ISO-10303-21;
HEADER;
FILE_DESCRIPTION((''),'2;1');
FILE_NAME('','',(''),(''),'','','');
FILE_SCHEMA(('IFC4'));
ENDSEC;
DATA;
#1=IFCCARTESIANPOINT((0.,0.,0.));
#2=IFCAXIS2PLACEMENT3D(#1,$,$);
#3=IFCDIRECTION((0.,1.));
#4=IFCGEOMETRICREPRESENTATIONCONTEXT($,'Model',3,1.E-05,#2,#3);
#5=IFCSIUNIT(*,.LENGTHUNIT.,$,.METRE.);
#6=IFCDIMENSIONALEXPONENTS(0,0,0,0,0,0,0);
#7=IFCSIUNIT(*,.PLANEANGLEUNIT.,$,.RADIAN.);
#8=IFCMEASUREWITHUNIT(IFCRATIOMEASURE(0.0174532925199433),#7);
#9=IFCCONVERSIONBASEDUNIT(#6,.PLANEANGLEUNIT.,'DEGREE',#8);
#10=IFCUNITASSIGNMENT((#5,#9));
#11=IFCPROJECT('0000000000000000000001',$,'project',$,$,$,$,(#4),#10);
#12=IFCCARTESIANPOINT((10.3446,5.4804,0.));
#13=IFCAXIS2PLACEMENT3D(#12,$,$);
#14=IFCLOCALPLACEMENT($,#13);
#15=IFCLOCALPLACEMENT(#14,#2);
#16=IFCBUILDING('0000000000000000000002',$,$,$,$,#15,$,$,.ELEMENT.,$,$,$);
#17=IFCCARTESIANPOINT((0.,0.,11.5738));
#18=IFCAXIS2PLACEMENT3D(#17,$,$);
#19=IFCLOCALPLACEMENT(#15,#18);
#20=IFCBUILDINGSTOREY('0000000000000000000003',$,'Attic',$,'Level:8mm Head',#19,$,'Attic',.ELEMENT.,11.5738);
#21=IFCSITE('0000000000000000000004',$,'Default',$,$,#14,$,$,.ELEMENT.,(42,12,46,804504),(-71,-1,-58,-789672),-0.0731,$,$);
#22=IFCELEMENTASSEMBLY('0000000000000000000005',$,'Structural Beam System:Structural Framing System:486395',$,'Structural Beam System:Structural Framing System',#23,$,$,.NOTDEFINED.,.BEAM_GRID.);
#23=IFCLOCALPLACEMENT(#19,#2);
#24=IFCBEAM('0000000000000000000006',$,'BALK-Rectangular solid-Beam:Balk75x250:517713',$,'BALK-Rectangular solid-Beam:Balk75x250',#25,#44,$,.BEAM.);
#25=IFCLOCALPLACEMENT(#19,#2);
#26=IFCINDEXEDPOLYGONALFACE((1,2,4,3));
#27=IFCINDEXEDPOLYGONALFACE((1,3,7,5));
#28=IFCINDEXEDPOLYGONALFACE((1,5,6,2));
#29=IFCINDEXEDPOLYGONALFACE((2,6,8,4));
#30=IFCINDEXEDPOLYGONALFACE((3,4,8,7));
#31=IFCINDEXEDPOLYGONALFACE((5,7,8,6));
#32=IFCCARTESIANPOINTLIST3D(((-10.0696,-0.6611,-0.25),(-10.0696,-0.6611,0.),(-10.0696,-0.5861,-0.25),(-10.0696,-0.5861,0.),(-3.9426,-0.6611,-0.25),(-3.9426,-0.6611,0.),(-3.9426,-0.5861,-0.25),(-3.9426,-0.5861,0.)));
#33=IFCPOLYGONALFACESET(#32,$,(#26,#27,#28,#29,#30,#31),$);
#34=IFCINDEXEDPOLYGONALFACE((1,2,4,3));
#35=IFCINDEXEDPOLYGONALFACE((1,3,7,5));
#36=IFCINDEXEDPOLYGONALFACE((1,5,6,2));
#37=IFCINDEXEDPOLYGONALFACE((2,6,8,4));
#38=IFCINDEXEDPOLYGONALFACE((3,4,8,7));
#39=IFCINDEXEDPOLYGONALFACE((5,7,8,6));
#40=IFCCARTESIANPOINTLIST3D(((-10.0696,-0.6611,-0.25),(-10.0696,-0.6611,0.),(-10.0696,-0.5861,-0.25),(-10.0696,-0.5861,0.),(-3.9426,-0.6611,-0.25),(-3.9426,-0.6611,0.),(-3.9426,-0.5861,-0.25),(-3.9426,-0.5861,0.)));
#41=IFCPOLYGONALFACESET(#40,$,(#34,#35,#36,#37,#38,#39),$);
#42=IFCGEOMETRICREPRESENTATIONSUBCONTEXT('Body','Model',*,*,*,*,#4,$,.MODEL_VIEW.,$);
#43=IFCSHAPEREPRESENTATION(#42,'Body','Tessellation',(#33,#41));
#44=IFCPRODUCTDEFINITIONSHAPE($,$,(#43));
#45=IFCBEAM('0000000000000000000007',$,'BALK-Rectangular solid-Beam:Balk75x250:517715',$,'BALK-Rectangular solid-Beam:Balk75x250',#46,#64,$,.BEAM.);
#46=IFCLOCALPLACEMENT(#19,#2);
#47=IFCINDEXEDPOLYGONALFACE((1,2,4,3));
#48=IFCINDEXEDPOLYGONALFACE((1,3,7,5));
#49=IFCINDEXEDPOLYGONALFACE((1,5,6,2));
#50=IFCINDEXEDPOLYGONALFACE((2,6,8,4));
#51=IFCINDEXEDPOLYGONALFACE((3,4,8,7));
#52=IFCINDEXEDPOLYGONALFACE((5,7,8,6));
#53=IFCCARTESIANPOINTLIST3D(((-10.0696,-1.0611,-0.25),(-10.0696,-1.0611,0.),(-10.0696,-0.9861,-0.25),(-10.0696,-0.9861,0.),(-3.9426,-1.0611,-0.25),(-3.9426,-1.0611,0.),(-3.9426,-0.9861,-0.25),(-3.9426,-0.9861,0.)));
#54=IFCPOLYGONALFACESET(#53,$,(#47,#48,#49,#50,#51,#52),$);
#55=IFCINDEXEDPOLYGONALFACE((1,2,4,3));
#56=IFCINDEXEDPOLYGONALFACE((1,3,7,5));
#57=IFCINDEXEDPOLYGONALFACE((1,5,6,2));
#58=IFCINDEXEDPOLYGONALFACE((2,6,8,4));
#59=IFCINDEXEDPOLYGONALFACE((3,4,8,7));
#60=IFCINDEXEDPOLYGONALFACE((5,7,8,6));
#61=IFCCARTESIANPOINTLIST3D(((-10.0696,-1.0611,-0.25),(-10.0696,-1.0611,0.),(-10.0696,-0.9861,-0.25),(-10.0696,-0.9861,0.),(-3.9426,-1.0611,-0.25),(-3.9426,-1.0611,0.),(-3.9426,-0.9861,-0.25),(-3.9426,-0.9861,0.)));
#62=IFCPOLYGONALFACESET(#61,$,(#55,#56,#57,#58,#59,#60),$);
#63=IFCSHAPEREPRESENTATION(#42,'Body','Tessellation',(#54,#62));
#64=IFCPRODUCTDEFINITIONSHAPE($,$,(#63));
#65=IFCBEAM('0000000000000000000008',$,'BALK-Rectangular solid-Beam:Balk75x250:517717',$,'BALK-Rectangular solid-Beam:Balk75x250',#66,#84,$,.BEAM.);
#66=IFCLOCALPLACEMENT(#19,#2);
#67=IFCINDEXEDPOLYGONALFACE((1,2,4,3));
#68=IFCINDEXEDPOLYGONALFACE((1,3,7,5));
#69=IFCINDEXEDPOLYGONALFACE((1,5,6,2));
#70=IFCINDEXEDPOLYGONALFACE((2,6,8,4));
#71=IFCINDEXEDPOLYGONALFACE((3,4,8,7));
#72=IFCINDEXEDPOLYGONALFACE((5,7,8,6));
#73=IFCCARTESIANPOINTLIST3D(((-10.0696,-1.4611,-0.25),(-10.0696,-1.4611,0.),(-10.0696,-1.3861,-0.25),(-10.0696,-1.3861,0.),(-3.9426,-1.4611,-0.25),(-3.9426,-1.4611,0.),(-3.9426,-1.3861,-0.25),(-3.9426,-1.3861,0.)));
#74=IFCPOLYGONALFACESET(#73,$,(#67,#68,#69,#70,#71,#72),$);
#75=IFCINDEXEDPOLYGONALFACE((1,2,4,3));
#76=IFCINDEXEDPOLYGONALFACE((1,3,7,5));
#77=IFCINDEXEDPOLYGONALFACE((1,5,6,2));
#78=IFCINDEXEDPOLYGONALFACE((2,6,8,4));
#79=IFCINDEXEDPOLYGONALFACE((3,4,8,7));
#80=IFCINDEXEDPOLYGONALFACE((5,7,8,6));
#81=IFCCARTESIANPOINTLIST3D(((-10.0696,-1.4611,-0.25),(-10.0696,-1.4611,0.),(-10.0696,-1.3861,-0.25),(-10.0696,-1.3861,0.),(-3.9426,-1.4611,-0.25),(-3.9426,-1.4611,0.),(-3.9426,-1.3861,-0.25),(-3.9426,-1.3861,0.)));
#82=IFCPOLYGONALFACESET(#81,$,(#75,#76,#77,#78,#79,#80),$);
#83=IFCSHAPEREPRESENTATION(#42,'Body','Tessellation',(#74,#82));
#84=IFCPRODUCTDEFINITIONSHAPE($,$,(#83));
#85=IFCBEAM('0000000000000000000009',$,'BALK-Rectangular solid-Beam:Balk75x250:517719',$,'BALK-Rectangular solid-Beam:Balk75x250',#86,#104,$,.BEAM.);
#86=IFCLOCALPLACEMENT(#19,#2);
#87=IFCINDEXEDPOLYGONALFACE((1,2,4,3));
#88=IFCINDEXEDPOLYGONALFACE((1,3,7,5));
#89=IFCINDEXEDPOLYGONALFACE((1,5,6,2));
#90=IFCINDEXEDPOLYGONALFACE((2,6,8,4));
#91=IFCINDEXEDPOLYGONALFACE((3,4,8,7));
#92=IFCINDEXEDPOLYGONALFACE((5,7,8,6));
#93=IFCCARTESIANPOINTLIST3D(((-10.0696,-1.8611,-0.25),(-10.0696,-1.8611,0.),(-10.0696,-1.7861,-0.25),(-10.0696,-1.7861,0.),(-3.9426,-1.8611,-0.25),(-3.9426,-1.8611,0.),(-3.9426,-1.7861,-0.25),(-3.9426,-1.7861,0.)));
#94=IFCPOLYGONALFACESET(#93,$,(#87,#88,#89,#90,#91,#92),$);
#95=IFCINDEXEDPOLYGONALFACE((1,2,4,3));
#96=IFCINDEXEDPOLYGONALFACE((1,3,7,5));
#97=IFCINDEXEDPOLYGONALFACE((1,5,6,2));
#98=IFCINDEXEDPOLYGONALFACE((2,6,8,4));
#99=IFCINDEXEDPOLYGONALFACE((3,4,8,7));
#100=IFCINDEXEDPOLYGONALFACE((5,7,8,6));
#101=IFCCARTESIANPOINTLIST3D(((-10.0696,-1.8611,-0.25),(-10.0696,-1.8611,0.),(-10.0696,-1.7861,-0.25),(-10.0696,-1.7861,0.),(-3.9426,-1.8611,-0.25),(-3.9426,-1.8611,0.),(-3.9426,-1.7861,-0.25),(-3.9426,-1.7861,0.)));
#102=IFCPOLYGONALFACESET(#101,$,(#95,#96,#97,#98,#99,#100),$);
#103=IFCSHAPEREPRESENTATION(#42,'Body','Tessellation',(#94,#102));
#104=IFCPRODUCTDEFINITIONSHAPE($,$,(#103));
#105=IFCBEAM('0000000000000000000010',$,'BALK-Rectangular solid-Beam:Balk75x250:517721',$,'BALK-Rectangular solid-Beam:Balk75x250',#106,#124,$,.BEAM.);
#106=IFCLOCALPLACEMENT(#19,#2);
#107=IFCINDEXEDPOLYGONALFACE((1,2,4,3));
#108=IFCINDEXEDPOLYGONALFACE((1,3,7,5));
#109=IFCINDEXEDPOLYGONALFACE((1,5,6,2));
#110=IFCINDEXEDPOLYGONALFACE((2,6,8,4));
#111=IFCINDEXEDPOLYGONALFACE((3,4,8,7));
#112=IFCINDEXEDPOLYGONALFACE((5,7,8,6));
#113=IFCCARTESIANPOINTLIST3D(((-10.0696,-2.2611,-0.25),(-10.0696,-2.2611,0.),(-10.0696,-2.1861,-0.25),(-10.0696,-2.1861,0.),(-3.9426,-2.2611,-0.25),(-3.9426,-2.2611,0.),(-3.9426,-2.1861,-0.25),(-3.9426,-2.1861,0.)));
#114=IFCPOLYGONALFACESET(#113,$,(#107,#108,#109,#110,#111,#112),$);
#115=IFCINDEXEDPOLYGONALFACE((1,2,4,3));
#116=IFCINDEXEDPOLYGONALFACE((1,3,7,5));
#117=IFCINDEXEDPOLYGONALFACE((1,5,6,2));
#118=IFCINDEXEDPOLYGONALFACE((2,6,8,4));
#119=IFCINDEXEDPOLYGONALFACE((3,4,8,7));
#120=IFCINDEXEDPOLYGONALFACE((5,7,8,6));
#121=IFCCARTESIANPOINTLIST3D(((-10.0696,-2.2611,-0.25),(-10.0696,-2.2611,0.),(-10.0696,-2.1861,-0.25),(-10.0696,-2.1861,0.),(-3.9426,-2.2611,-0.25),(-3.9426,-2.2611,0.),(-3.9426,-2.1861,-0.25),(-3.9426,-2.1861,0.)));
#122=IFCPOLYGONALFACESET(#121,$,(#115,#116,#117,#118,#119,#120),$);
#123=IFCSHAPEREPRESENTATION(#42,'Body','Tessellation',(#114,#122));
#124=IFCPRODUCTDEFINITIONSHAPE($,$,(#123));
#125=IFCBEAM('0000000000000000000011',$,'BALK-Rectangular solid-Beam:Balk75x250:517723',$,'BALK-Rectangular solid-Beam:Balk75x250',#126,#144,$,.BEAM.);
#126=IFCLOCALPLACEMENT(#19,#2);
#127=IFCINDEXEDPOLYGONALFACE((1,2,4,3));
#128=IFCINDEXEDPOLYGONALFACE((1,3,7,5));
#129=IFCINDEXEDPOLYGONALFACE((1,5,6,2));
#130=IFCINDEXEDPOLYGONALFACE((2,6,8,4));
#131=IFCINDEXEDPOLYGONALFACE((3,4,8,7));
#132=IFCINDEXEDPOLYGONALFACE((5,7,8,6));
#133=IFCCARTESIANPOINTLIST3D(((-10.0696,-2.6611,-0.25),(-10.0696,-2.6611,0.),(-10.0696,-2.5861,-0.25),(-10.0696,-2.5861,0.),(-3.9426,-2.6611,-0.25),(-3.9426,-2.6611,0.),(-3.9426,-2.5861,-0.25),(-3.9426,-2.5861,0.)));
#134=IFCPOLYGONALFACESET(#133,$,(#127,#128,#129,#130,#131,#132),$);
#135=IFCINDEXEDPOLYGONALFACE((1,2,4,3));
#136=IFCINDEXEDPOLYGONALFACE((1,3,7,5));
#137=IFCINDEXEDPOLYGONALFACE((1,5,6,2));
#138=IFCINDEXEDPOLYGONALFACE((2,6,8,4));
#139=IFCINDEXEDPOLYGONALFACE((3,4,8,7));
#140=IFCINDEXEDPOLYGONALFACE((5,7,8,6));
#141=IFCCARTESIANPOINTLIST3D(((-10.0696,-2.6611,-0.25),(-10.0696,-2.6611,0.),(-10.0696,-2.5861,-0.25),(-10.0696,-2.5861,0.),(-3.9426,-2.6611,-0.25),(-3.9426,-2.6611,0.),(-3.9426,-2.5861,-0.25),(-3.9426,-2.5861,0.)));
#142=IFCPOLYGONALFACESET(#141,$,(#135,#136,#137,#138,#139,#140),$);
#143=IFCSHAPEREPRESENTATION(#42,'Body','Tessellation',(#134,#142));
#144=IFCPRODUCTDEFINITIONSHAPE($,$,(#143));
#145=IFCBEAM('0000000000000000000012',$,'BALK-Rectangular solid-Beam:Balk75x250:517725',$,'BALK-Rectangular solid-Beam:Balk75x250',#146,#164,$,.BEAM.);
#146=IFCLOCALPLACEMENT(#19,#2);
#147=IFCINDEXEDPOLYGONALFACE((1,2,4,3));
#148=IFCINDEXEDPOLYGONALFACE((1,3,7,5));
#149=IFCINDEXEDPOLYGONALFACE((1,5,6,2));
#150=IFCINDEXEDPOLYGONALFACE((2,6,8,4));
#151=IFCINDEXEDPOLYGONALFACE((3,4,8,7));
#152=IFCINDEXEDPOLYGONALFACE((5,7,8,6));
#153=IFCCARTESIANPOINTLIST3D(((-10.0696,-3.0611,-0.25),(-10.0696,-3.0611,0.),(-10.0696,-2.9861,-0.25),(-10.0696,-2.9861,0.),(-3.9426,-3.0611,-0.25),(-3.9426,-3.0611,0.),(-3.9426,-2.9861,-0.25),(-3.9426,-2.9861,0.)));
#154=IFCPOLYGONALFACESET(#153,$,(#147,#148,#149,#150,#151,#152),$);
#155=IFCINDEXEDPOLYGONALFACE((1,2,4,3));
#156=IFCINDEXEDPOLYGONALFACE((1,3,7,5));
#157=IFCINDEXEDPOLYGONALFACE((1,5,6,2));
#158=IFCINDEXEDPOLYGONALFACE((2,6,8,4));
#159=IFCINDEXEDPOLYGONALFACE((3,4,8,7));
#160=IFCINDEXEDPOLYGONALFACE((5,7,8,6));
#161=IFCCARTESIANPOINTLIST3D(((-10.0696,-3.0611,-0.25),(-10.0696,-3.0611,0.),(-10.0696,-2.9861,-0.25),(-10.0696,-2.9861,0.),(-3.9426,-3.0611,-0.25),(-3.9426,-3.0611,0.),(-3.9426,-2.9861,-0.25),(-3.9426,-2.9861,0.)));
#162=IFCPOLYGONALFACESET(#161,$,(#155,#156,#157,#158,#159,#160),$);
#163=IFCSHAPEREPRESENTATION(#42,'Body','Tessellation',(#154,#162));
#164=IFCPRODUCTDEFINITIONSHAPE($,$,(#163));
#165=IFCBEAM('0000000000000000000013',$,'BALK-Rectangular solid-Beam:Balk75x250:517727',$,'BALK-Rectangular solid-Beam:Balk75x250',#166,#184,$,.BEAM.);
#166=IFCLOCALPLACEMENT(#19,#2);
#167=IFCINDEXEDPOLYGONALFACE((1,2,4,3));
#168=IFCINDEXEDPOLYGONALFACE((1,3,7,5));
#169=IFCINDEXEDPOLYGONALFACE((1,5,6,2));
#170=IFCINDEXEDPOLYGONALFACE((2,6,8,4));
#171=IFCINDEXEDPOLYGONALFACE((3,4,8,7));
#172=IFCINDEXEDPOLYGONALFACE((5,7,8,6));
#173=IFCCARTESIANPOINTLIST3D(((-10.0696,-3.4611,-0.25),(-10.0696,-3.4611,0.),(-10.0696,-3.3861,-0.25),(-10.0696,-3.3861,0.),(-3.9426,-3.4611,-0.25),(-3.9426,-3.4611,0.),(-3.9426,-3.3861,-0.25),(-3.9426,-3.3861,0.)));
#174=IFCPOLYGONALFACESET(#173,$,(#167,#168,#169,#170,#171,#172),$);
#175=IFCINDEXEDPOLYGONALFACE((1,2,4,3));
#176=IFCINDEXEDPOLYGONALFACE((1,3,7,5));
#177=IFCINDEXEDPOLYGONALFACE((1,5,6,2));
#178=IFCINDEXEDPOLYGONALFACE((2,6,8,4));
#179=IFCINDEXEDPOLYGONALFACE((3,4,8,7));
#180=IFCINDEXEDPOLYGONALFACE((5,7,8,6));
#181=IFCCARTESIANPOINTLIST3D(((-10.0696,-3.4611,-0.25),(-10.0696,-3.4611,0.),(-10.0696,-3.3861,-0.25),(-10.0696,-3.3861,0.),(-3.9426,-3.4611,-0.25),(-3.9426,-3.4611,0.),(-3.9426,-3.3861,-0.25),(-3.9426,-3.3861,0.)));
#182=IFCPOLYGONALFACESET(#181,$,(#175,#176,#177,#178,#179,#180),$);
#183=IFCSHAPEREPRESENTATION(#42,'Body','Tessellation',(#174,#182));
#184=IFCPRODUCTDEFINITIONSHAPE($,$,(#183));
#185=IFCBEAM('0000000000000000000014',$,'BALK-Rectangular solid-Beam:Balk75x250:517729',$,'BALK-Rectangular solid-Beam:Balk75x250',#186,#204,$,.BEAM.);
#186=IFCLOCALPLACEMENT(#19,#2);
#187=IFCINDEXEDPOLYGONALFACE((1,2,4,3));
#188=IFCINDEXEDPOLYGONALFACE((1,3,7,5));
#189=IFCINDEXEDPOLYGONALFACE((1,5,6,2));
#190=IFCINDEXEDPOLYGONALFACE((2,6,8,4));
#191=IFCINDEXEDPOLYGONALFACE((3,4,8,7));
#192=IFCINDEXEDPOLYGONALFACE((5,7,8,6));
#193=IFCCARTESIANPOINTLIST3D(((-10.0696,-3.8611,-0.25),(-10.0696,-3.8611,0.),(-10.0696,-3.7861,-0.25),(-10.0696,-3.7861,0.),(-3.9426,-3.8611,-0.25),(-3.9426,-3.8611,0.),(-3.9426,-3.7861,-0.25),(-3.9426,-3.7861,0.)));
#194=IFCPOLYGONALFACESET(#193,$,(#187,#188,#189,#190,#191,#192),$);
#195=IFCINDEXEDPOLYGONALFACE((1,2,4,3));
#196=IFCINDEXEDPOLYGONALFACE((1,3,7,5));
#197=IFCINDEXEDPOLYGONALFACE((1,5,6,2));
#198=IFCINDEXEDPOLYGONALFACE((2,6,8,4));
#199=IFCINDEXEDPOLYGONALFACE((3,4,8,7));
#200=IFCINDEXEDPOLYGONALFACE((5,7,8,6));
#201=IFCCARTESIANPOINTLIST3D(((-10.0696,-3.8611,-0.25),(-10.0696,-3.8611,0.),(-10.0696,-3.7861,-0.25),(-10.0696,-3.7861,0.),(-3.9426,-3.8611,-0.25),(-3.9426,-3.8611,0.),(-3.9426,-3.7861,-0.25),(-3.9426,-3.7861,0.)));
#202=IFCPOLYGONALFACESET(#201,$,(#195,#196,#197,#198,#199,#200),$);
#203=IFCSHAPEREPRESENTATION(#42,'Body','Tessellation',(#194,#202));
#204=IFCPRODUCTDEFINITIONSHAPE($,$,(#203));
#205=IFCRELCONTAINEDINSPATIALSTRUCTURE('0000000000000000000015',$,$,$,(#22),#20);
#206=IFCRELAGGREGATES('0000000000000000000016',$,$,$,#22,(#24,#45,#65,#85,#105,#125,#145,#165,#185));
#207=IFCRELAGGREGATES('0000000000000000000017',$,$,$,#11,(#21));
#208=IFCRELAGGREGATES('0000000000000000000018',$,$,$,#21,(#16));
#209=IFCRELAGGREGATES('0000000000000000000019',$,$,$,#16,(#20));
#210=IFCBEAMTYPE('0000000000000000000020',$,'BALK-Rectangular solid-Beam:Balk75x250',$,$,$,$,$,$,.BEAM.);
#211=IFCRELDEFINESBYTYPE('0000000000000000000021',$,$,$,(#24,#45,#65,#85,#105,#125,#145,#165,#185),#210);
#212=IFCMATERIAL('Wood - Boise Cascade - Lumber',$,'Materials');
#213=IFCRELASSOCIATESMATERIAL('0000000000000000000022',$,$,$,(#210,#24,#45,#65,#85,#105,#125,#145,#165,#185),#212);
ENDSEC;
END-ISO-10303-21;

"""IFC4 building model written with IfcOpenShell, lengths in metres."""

from ifc_helpers import new_model, entity, si_unit, converted_unit, direction, frame, frame_2d, origin, origin_2d_with_axis, place, context, subcontext, project, spatial, rectangle, extrude, source, transform, mapped, material, material_profile, profile_set, profile_usage, type_object, type_shapes, element, aggregate, save


model = new_model("IFC4")

# Units and contexts
model_context = context("Model", 3, precision=1e-05, world=origin(), true_north=direction((0.0, 1.0)))
body_context = subcontext(model_context, "Body", "Model", "MODEL_VIEW")
ifc_project = project(units=[si_unit("LENGTHUNIT", "METRE"), converted_unit("PLANEANGLEUNIT", "DEGREE", entity("IfcRatioMeasure", 0.0174532925199433), si_unit("PLANEANGLEUNIT", "RADIAN"), dimensions=[0, 0, 0, 0, 0, 0, 0])], contexts=[model_context])

# Site, building, storey
site_placement = place(None, frame((10.3446, 5.4804, 0.0)))
site = spatial("IfcSite", under=ifc_project, at=site_placement, Name="Default", CompositionType="ELEMENT", RefLatitude=(42, 12, 46, 804504), RefLongitude=(-71, -1, -58, -789672), RefElevation=-0.0731)
building_placement = place(site_placement, origin())
building = spatial("IfcBuilding", under=site, at=building_placement, CompositionType="ELEMENT")
storey_placement = place(building_placement, frame((0.0, 0.0, 11.5738)))
storey = spatial("IfcBuildingStorey", under=building, at=storey_placement, Name="Attic", ObjectType="Level:8mm Head", LongName="Attic", CompositionType="ELEMENT", Elevation=11.5738)

# Element assembly, beams
ifc_material = material(Name="Wood - Boise Cascade - Lumber", Category="Materials")
ifc_material_profile = material_profile(ifc_material, rectangle(XDim=0.25, YDim=0.075, at=frame_2d((0.0, 0.0), x_axis=(1.0, 0.0))), Name="Balk75x250")
ifc_profile_set = profile_set([ifc_material_profile], Name="Balk75x250")
assembly_1_placement = place(storey_placement, origin())
assembly_1 = element("IfcElementAssembly", 1, at=assembly_1_placement, inside=storey, Name="Structural Beam System:Structural Framing System:486395", ObjectType="Structural Beam System:Structural Framing System", AssemblyPlace="NOTDEFINED", PredefinedType="BEAM_GRID")
beam_type_1 = type_object("IfcBeamType", Name="BALK-Rectangular solid-Beam:Balk75x250", PredefinedType="BEAM", material=ifc_profile_set)
shared_shape_1 = source(origin(), body_context, "Body", "SweptSolid", [
    extrude(rectangle(XDim=0.25, YDim=0.075, at=origin_2d_with_axis()), frame((-2.9698, 0.0, 0.0), z_axis=(1.0, 0.0, 0.0), x_axis=(0.0, 0.0, -1.0)), (0.0, 0.0, 1.0), 6.127),
    extrude(rectangle(XDim=0.25, YDim=0.075, at=origin_2d_with_axis()), frame((-2.9698, 0.0, 0.0), z_axis=(1.0, 0.0, 0.0), x_axis=(0.0, 0.0, -1.0)), (0.0, 0.0, 1.0), 6.127),
])
type_shapes(beam_type_1, [shared_shape_1])
ifc_profile_usage_1 = profile_usage(ifc_profile_set, cardinal=8)
beam_1_placement = place(assembly_1_placement, frame((-7.0999, -0.6236, -0.125)))
beam_1 = element("IfcBeam", 2, at=beam_1_placement, type_object=beam_type_1, material=ifc_profile_usage_1, Name="BALK-Rectangular solid-Beam:Balk75x250:517713", ObjectType="BALK-Rectangular solid-Beam:Balk75x250", PredefinedType="BEAM", context=body_context, shape_type="MappedRepresentation", body=[
    mapped(shared_shape_1, transform((0.0, 0.0, 0.0), scale=1.0)),
])
ifc_profile_usage_2 = profile_usage(ifc_profile_set, cardinal=8)
beam_2_placement = place(assembly_1_placement, frame((-7.0999, -1.0236, -0.125)))
beam_2 = element("IfcBeam", 3, at=beam_2_placement, type_object=beam_type_1, material=ifc_profile_usage_2, Name="BALK-Rectangular solid-Beam:Balk75x250:517715", ObjectType="BALK-Rectangular solid-Beam:Balk75x250", PredefinedType="BEAM", context=body_context, shape_type="MappedRepresentation", body=[
    mapped(shared_shape_1, transform((0.0, 0.0, 0.0), scale=1.0)),
])
ifc_profile_usage_3 = profile_usage(ifc_profile_set, cardinal=8)
beam_3_placement = place(assembly_1_placement, frame((-7.0999, -1.4236, -0.125)))
beam_3 = element("IfcBeam", 4, at=beam_3_placement, type_object=beam_type_1, material=ifc_profile_usage_3, Name="BALK-Rectangular solid-Beam:Balk75x250:517717", ObjectType="BALK-Rectangular solid-Beam:Balk75x250", PredefinedType="BEAM", context=body_context, shape_type="MappedRepresentation", body=[
    mapped(shared_shape_1, transform((0.0, 0.0, 0.0), scale=1.0)),
])
ifc_profile_usage_4 = profile_usage(ifc_profile_set, cardinal=8)
beam_4_placement = place(assembly_1_placement, frame((-7.0999, -1.8236, -0.125)))
beam_4 = element("IfcBeam", 5, at=beam_4_placement, type_object=beam_type_1, material=ifc_profile_usage_4, Name="BALK-Rectangular solid-Beam:Balk75x250:517719", ObjectType="BALK-Rectangular solid-Beam:Balk75x250", PredefinedType="BEAM", context=body_context, shape_type="MappedRepresentation", body=[
    mapped(shared_shape_1, transform((0.0, 0.0, 0.0), scale=1.0)),
])
ifc_profile_usage_5 = profile_usage(ifc_profile_set, cardinal=8)
beam_5_placement = place(assembly_1_placement, frame((-7.0999, -2.2236, -0.125)))
beam_5 = element("IfcBeam", 6, at=beam_5_placement, type_object=beam_type_1, material=ifc_profile_usage_5, Name="BALK-Rectangular solid-Beam:Balk75x250:517721", ObjectType="BALK-Rectangular solid-Beam:Balk75x250", PredefinedType="BEAM", context=body_context, shape_type="MappedRepresentation", body=[
    mapped(shared_shape_1, transform((0.0, 0.0, 0.0), scale=1.0)),
])
ifc_profile_usage_6 = profile_usage(ifc_profile_set, cardinal=8)
beam_6_placement = place(assembly_1_placement, frame((-7.0999, -2.6236, -0.125)))
beam_6 = element("IfcBeam", 7, at=beam_6_placement, type_object=beam_type_1, material=ifc_profile_usage_6, Name="BALK-Rectangular solid-Beam:Balk75x250:517723", ObjectType="BALK-Rectangular solid-Beam:Balk75x250", PredefinedType="BEAM", context=body_context, shape_type="MappedRepresentation", body=[
    mapped(shared_shape_1, transform((0.0, 0.0, 0.0), scale=1.0)),
])
ifc_profile_usage_7 = profile_usage(ifc_profile_set, cardinal=8)
beam_7_placement = place(assembly_1_placement, frame((-7.0999, -3.0236, -0.125)))
beam_7 = element("IfcBeam", 8, at=beam_7_placement, type_object=beam_type_1, material=ifc_profile_usage_7, Name="BALK-Rectangular solid-Beam:Balk75x250:517725", ObjectType="BALK-Rectangular solid-Beam:Balk75x250", PredefinedType="BEAM", context=body_context, shape_type="MappedRepresentation", body=[
    mapped(shared_shape_1, transform((0.0, 0.0, 0.0), scale=1.0)),
])
ifc_profile_usage_8 = profile_usage(ifc_profile_set, cardinal=8)
beam_8_placement = place(assembly_1_placement, frame((-7.0999, -3.4236, -0.125)))
beam_8 = element("IfcBeam", 9, at=beam_8_placement, type_object=beam_type_1, material=ifc_profile_usage_8, Name="BALK-Rectangular solid-Beam:Balk75x250:517727", ObjectType="BALK-Rectangular solid-Beam:Balk75x250", PredefinedType="BEAM", context=body_context, shape_type="MappedRepresentation", body=[
    mapped(shared_shape_1, transform((0.0, 0.0, 0.0), scale=1.0)),
])
ifc_profile_usage_9 = profile_usage(ifc_profile_set, cardinal=8)
beam_9_placement = place(assembly_1_placement, frame((-7.0999, -3.8236, -0.125)))
beam_9 = element("IfcBeam", 10, at=beam_9_placement, type_object=beam_type_1, material=ifc_profile_usage_9, Name="BALK-Rectangular solid-Beam:Balk75x250:517729", ObjectType="BALK-Rectangular solid-Beam:Balk75x250", PredefinedType="BEAM", context=body_context, shape_type="MappedRepresentation", body=[
    mapped(shared_shape_1, transform((0.0, 0.0, 0.0), scale=1.0)),
])
aggregate(assembly_1, [beam_1, beam_2, beam_3, beam_4, beam_5, beam_6, beam_7, beam_8, beam_9])

save(model, "model.ifc")
